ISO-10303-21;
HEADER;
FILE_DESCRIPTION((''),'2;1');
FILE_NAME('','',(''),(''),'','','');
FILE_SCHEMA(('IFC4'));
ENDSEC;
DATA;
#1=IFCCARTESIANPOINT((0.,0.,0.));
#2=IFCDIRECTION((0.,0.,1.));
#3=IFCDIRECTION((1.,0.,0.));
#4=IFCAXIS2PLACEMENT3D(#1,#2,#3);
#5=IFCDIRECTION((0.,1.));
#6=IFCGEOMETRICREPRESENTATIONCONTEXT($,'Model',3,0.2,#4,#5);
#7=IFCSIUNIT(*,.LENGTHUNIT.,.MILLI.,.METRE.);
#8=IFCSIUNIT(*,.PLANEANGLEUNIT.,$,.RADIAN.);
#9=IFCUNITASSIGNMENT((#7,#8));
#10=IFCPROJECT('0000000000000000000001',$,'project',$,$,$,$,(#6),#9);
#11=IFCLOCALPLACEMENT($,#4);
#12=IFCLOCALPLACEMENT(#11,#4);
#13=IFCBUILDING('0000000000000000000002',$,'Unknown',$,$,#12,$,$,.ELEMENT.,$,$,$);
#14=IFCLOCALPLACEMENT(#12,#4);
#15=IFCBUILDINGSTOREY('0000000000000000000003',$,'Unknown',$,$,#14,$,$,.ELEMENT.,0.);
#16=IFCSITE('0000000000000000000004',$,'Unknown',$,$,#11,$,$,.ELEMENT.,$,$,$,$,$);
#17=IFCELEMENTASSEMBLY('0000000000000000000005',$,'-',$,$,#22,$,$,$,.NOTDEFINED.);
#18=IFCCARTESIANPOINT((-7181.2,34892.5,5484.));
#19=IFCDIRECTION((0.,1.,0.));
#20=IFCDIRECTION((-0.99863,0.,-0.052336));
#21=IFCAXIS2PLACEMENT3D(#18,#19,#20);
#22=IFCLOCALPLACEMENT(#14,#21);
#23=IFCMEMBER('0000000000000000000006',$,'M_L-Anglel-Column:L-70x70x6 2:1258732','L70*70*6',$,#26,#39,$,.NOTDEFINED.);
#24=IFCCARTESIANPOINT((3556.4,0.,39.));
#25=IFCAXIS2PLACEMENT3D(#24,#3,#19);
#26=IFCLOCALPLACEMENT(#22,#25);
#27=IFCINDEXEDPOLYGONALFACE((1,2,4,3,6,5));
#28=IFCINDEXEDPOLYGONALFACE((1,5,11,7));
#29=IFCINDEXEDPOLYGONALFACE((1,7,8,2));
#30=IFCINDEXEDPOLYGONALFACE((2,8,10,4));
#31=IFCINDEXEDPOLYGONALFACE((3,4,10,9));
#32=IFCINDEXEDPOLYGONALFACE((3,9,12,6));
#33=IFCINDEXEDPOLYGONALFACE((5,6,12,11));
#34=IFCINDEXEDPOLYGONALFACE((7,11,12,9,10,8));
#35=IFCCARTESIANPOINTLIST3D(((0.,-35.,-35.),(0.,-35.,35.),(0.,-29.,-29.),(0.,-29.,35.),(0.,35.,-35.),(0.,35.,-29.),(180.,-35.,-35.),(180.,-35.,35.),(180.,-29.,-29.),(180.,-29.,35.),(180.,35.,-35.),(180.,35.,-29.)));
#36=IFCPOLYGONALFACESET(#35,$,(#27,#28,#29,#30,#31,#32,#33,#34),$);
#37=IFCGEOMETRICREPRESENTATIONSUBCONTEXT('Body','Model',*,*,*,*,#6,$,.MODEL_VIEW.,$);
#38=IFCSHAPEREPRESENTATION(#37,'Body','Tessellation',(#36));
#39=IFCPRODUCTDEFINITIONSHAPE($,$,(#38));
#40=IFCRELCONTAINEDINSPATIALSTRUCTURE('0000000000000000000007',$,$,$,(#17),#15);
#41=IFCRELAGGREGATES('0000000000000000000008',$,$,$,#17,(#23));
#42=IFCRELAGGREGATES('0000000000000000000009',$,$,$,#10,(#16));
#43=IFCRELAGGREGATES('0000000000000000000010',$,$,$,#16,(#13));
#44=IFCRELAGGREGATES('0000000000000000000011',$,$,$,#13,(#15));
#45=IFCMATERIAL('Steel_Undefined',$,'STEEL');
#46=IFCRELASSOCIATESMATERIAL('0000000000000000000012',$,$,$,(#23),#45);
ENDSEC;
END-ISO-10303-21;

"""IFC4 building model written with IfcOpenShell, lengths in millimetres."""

from ifc_helpers import new_model, si_unit, direction, frame, origin_with_axes, place, context, subcontext, project, spatial, line, indexed_curve, outline, extrude, material, element, aggregate, save


model = new_model("IFC4")

# Units and contexts
model_context = context("Model", 3, precision=0.2, world=origin_with_axes(), true_north=direction((0.0, 1.0)))
body_context = subcontext(model_context, "Body", "Model", "MODEL_VIEW")
ifc_project = project(units=[si_unit("LENGTHUNIT", "METRE", prefix="MILLI"), si_unit("PLANEANGLEUNIT", "RADIAN")], contexts=[model_context])

# Site, building, storey
site_placement = place(None, origin_with_axes())
site = spatial("IfcSite", under=ifc_project, at=site_placement, Name="Unknown", CompositionType="ELEMENT")
building_placement = place(site_placement, origin_with_axes())
building = spatial("IfcBuilding", under=site, at=building_placement, Name="Unknown", CompositionType="ELEMENT")
storey_placement = place(building_placement, origin_with_axes())
storey = spatial("IfcBuildingStorey", under=building, at=storey_placement, Name="Unknown", CompositionType="ELEMENT", Elevation=0.0)

# Element assembly, member
assembly_1_placement = place(storey_placement, frame((-7181.2, 34892.5, 5484.0), z_axis=(0.0, 1.0, 0.0), x_axis=(-0.99863, 0.0, -0.052336)))
assembly_1 = element("IfcElementAssembly", 1, at=assembly_1_placement, inside=storey, Name="-", PredefinedType="NOTDEFINED")
ifc_material_1 = material(Name="Steel_Undefined", Category="STEEL")
member_placement = place(assembly_1_placement, frame((3556.4, 0.0, 39.0), z_axis=(1.0, 0.0, 0.0), x_axis=(0.0, 1.0, 0.0)))
member = element("IfcMember", 2, at=member_placement, material=ifc_material_1, Name="M_L-Anglel-Column:L-70x70x6 2:1258732", Description="L70*70*6", PredefinedType="NOTDEFINED", context=body_context, shape_type="SolidModel", body=[
    extrude(outline(indexed_curve([(-35.0, -35.0), (35.0, -35.0), (35.0, -29.0), (-29.0, -29.0), (-29.0, 35.0), (-35.0, 35.0)], segments=[line(1, 2, 3, 4, 5, 6, 1)])), frame((0.0, 0.0, 0.0), z_axis=(-1.0, 0.0, 0.0), x_axis=(0.0, 0.0, 1.0)), (0.0, 0.0, -1.0), 180.0),
])
aggregate(assembly_1, [member])

save(model, "model.ifc")
